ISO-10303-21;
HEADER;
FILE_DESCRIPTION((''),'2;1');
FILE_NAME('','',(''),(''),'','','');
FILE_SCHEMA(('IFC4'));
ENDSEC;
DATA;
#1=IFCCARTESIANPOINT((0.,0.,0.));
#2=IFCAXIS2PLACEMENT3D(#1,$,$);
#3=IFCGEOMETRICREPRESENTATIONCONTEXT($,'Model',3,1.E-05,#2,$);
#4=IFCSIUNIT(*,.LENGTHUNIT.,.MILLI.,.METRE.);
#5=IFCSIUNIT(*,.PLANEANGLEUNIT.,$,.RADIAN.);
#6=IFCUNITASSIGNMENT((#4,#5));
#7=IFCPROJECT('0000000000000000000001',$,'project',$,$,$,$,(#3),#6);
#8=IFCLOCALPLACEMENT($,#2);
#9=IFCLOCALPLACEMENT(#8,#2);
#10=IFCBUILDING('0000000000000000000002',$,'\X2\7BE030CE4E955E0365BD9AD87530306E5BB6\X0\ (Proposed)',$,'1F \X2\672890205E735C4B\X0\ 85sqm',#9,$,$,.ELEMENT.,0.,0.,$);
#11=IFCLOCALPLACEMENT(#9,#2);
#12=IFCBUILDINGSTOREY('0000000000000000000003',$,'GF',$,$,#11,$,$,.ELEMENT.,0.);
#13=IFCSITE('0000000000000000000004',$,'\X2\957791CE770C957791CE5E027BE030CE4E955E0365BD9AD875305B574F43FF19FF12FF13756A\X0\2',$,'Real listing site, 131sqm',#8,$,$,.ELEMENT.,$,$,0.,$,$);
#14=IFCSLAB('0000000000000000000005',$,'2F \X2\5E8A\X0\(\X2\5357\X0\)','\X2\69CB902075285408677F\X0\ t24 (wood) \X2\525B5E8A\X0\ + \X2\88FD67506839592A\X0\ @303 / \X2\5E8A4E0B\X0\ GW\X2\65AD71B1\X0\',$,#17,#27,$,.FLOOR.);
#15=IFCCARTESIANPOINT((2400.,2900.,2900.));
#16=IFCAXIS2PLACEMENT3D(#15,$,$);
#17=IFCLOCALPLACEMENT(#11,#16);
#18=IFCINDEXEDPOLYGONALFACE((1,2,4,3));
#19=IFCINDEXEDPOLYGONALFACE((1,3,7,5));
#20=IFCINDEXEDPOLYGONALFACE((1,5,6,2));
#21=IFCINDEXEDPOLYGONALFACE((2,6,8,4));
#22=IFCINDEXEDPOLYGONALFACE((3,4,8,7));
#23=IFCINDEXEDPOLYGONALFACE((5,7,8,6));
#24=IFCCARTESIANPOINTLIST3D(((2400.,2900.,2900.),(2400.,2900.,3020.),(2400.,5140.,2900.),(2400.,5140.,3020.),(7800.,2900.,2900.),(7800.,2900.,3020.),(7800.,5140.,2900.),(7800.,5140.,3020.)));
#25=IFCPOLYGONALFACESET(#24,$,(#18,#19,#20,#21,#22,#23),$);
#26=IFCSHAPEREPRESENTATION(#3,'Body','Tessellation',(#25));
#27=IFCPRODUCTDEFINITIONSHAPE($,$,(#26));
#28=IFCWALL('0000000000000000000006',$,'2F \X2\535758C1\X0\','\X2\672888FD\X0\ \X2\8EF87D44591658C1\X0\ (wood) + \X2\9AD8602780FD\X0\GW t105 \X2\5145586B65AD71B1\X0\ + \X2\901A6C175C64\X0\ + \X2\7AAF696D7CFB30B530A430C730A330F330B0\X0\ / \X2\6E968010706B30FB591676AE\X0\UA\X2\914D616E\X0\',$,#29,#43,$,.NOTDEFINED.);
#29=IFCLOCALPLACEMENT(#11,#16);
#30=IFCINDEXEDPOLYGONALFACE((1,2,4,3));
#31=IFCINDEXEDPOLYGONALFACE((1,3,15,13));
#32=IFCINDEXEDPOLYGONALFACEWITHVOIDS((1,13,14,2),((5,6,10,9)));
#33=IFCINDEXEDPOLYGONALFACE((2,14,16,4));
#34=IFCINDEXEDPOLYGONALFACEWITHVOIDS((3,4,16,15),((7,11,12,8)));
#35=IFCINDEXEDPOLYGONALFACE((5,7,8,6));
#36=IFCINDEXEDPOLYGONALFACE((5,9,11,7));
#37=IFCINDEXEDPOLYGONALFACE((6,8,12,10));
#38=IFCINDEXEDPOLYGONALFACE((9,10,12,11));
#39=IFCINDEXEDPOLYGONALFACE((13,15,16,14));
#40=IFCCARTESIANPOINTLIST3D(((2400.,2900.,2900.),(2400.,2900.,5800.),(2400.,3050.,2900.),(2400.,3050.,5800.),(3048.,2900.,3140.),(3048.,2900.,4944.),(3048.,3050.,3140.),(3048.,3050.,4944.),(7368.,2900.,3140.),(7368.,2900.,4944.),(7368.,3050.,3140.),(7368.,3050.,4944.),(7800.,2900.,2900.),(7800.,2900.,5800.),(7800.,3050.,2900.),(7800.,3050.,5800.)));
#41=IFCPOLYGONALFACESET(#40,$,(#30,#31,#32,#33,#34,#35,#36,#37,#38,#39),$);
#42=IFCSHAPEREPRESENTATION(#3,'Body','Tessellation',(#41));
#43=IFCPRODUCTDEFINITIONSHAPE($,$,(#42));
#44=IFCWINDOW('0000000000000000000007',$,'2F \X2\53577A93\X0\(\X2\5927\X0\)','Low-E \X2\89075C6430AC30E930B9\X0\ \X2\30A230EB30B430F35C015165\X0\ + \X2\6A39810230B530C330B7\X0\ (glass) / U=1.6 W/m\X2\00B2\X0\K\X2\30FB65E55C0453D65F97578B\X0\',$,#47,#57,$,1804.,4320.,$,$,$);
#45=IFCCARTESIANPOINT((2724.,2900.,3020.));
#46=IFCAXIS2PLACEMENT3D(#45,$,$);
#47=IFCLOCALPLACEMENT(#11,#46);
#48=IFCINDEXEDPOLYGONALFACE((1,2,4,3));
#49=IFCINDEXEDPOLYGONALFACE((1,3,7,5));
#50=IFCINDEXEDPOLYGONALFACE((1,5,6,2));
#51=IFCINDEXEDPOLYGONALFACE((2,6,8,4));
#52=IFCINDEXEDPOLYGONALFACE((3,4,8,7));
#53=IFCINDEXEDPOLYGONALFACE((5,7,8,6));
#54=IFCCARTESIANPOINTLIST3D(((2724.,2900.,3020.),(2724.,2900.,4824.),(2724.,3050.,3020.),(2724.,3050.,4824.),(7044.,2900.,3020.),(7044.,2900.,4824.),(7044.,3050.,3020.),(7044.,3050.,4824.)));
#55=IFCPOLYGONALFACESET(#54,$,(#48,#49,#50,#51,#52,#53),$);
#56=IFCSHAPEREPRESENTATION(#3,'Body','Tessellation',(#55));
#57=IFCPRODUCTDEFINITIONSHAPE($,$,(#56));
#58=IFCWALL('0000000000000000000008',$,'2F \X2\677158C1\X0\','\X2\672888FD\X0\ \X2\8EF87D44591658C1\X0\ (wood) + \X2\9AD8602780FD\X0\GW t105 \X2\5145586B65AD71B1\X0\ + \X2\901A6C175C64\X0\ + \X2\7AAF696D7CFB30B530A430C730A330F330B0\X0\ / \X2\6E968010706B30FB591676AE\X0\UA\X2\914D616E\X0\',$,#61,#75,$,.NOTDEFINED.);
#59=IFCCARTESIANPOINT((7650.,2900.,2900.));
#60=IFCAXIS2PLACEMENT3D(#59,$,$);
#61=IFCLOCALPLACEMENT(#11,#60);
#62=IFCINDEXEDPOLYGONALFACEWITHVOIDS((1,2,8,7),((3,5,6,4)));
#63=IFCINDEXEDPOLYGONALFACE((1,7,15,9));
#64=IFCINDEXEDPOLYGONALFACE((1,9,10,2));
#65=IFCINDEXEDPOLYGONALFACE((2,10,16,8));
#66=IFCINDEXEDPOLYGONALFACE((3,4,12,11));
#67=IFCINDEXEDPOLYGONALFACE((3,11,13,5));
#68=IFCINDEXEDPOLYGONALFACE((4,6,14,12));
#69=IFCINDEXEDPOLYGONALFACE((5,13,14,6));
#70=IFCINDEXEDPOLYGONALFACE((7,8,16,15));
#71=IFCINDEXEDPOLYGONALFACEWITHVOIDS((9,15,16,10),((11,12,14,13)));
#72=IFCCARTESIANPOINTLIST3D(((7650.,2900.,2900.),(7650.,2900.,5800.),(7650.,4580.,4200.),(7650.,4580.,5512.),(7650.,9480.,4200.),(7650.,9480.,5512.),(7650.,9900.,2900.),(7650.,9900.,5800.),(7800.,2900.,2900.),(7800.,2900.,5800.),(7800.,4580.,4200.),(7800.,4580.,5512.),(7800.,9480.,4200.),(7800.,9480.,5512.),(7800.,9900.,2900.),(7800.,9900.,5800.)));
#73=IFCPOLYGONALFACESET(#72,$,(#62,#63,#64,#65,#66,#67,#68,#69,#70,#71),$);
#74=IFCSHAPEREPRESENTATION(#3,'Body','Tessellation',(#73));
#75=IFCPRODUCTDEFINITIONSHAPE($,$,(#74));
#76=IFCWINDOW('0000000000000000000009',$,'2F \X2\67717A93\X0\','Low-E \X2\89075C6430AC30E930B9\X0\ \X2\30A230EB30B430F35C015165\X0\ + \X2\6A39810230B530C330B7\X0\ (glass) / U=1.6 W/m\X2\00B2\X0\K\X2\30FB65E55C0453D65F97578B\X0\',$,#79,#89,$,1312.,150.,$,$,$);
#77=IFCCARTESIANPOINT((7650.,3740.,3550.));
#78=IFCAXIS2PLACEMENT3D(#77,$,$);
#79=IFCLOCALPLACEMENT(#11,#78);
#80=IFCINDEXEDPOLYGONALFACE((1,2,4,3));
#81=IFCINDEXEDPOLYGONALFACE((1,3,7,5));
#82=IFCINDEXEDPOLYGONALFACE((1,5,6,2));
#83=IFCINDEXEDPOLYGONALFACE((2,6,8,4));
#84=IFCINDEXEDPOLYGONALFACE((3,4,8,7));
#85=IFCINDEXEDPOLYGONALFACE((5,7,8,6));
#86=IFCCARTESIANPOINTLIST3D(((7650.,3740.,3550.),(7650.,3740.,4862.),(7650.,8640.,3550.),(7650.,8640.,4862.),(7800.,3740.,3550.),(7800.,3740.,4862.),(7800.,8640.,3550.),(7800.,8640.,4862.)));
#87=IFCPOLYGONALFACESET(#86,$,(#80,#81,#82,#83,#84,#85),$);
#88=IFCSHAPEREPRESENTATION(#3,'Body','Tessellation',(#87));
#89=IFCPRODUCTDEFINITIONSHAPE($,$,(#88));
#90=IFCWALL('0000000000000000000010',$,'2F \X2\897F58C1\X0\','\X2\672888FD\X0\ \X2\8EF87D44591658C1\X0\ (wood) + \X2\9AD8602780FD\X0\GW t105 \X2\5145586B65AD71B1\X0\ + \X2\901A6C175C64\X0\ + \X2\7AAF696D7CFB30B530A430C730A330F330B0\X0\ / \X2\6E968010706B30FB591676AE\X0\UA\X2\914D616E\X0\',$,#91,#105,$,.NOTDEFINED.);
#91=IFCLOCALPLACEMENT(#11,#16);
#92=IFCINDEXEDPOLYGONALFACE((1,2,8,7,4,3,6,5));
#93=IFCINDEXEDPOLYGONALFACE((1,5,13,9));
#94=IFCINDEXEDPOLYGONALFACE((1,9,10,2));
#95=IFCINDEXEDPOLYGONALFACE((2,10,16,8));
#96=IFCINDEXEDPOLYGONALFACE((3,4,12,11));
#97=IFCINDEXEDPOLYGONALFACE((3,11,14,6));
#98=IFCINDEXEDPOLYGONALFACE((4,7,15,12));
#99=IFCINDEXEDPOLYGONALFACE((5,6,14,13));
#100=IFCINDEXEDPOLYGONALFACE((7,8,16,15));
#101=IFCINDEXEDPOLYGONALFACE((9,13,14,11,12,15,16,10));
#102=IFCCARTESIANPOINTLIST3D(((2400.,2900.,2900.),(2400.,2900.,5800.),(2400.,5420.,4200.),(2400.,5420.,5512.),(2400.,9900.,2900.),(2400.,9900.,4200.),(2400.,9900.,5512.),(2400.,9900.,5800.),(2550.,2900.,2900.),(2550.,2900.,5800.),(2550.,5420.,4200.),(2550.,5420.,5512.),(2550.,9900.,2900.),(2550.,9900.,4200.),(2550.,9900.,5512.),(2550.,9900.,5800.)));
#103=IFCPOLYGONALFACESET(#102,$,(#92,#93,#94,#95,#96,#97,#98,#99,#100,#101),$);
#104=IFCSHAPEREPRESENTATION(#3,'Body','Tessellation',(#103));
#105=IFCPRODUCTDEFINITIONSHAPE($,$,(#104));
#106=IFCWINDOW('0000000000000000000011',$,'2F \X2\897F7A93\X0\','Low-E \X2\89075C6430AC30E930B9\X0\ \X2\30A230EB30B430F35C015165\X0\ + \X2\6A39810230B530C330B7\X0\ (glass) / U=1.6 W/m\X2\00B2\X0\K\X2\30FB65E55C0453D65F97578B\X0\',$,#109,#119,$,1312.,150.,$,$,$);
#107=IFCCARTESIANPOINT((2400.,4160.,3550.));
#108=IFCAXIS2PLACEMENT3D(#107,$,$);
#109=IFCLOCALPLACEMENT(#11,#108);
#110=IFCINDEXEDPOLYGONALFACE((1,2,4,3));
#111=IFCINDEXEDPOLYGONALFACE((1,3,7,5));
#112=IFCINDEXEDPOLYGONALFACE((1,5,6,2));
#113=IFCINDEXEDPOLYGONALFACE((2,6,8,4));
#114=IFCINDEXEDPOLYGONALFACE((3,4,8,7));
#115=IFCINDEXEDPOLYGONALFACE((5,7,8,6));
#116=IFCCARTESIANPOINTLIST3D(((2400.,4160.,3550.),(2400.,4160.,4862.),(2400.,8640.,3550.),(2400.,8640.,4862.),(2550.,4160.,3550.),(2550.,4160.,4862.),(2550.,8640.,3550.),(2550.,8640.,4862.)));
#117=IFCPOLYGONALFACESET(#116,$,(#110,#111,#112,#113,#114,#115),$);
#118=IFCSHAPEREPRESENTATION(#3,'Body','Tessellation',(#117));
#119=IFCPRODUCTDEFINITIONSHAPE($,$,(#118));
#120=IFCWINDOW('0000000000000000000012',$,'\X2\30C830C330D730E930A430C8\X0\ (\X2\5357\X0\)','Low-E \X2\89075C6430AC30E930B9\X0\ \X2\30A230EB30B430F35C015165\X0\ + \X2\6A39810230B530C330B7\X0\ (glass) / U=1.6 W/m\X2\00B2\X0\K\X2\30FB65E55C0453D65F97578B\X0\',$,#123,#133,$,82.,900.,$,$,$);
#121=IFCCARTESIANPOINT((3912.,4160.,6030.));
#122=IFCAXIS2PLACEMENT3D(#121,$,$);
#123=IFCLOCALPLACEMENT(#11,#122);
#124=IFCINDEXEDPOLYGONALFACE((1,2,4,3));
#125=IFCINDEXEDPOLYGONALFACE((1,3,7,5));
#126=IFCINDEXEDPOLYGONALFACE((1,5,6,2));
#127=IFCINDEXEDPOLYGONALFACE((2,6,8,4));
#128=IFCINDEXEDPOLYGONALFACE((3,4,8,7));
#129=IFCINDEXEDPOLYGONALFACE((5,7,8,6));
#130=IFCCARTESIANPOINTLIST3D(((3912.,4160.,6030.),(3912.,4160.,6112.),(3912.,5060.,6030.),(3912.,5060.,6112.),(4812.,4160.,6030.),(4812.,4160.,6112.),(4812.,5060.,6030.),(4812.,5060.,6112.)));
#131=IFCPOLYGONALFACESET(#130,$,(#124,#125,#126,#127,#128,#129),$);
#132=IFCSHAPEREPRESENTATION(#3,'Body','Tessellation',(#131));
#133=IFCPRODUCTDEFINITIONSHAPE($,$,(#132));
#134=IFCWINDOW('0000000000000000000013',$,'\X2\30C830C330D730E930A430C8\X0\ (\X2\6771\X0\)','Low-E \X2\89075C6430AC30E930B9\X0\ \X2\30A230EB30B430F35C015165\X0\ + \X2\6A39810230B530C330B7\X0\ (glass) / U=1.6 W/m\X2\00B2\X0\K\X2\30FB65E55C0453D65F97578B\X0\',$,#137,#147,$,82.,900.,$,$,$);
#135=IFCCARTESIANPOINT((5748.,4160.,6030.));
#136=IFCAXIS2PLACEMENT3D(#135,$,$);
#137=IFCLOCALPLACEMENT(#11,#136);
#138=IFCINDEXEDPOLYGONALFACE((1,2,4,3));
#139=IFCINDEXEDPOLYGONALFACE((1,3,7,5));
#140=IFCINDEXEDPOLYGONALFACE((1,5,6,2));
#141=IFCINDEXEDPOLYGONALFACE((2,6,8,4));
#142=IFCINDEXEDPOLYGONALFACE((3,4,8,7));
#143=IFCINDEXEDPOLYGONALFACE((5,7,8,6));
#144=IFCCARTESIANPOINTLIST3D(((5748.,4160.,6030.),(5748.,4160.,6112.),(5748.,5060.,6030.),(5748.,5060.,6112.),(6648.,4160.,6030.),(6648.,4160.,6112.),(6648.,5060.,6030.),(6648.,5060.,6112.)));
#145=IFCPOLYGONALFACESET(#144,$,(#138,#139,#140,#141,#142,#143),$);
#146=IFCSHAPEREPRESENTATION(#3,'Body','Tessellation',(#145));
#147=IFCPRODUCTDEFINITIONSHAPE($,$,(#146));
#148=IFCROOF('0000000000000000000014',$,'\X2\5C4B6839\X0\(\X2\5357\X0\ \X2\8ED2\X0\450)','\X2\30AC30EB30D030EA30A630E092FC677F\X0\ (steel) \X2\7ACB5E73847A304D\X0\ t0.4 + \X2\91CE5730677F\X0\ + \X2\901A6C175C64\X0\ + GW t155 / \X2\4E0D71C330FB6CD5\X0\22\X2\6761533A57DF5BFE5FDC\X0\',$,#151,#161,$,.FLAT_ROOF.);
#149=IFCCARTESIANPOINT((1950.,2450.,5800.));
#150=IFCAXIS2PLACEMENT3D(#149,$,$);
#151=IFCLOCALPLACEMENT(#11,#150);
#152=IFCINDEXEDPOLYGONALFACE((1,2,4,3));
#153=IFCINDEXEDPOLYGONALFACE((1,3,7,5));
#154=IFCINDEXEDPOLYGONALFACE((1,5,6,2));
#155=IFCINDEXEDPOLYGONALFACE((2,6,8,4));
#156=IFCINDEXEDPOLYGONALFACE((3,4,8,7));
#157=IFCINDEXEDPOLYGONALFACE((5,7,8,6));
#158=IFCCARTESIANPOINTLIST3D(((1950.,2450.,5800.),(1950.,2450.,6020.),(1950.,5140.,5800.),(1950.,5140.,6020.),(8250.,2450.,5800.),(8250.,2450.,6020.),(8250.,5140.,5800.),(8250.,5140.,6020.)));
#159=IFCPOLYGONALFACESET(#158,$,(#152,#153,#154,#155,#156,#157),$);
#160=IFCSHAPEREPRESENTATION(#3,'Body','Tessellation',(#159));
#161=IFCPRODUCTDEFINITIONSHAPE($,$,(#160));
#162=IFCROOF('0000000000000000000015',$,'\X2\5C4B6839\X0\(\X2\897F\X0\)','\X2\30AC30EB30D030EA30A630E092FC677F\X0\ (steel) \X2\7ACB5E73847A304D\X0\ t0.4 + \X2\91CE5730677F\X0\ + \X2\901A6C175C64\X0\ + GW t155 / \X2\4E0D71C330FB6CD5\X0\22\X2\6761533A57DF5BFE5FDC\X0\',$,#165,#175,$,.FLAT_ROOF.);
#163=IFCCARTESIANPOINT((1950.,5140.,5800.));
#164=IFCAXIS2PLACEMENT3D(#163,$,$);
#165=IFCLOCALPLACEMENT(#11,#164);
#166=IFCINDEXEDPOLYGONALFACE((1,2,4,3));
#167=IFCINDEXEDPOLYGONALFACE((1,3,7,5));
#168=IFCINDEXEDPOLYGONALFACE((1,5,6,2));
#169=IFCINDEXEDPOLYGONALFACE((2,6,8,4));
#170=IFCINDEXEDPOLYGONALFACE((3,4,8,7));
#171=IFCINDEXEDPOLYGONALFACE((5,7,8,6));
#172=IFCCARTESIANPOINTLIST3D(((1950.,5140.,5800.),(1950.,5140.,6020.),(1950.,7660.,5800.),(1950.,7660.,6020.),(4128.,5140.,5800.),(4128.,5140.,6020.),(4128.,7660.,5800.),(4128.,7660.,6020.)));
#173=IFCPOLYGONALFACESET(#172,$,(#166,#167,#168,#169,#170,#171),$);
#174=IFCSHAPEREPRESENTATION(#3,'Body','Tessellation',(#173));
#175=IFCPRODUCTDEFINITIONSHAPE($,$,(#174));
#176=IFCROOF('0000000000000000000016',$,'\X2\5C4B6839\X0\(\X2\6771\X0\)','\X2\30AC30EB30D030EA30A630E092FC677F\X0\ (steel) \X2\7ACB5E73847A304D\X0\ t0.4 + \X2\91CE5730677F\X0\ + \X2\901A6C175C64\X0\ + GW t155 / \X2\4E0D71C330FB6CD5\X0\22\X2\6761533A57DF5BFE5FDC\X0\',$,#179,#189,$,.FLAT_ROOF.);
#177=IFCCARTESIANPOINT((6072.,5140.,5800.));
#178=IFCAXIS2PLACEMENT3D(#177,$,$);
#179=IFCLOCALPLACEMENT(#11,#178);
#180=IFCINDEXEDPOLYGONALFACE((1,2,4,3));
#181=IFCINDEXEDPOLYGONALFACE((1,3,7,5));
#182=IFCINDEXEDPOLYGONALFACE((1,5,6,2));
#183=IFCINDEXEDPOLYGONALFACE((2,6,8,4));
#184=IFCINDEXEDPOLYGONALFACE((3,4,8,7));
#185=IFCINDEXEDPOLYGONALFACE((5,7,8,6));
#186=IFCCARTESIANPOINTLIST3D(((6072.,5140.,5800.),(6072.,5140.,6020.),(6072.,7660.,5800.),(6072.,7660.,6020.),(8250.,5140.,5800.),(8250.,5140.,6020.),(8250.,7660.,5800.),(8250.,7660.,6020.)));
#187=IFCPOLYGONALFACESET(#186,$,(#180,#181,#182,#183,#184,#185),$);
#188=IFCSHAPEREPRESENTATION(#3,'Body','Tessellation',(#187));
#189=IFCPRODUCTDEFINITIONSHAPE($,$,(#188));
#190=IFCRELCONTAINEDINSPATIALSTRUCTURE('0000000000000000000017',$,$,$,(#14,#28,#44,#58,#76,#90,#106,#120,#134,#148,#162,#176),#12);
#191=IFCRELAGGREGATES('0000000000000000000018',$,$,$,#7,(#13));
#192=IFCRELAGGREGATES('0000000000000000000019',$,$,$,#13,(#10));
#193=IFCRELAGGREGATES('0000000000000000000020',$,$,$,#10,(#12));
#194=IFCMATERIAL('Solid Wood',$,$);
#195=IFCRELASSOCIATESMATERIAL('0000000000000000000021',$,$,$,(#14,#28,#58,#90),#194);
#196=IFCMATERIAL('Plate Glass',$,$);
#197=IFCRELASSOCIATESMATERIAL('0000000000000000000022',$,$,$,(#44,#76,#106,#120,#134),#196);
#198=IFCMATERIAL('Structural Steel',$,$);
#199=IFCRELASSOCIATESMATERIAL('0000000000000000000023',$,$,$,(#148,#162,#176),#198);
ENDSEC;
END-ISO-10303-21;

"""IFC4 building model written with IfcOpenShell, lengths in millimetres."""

from ifc_helpers import new_model, si_unit, frame, frame_2d, origin, place, context, project, spatial, rectangle, extrude, material, element, fill, save


model = new_model("IFC4")

# Units and contexts
model_context = context("Model", 3, precision=1e-05, world=origin())
ifc_project = project(units=[si_unit("LENGTHUNIT", "METRE", prefix="MILLI"), si_unit("PLANEANGLEUNIT", "RADIAN")], contexts=[model_context])

# Site, building, storey
site_placement = place(None, origin())
site = spatial("IfcSite", under=ifc_project, at=site_placement, Name="長野県長野市篠ノ井布施高田字佃９２３番2", ObjectType="Real listing site, 131sqm", CompositionType="ELEMENT", RefElevation=0.0)
building_placement = place(site_placement, origin())
building = spatial("IfcBuilding", under=site, at=building_placement, Name="篠ノ井布施高田の家 (Proposed)", ObjectType="1F 木造平屋 85sqm", CompositionType="ELEMENT", ElevationOfRefHeight=0.0, ElevationOfTerrain=0.0)
storey_placement = place(building_placement, origin())
storey = spatial("IfcBuildingStorey", under=building, at=storey_placement, Name="GF", CompositionType="ELEMENT", Elevation=0.0)

# Slab
ifc_material_1 = material(Name="Solid Wood")
slab_placement = place(storey_placement, frame((2400.0, 2900.0, 2900.0)))
element("IfcSlab", 1, at=slab_placement, inside=storey, material=ifc_material_1, Name="2F 床(南)", Description="構造用合板 t24 (wood) 剛床 + 製材根太 @303 / 床下 GW断熱", PredefinedType="FLOOR", context=model_context, shape_type="SweptSolid", body=[
    extrude(rectangle(XDim=5400.0, YDim=2240.0, at=frame_2d((2700.0, 1120.0))), frame((2400.0, 2900.0, 2900.0)), (0.0, 0.0, 1.0), 120.0),
])

# Walls, openings, windows
wall_1_placement = place(storey_placement, frame((2400.0, 2900.0, 2900.0)))
wall_1 = element("IfcWall", 2, at=wall_1_placement, inside=storey, material=ifc_material_1, Name="2F 南壁", Description="木製 軸組外壁 (wood) + 高性能GW t105 充填断熱 + 通気層 + 窯業系サイディング / 準耐火・外皮UA配慮", PredefinedType="NOTDEFINED", context=model_context, shape_type="SweptSolid", body=[
    extrude(rectangle(XDim=5400.0, YDim=150.0, at=frame_2d((2700.0, 75.0))), frame((2400.0, 2900.0, 2900.0)), (0.0, 0.0, 1.0), 2900.0),
])
opening_1_placement = place(storey_placement, frame((2724.0, 2900.0, 3020.0)))
opening_1 = element("IfcOpeningElement", 3, at=opening_1_placement, cuts=wall_1, PredefinedType="NOTDEFINED", context=model_context, shape_type="SweptSolid", body=[
    extrude(rectangle(XDim=4320.0, YDim=150.0, at=frame_2d((2160.0, 75.0))), frame((2724.0, 2900.0, 3020.0)), (0.0, 0.0, 1.0), 1804.0),
])
ifc_material_2 = material(Name="Plate Glass")
window_1_placement = place(storey_placement, frame((2724.0, 2900.0, 3020.0)))
window_1 = element("IfcWindow", 4, at=window_1_placement, inside=storey, material=ifc_material_2, Name="2F 南窓(大)", Description="Low-E 複層ガラス アルゴン封入 + 樹脂サッシ (glass) / U=1.6 W/m²K・日射取得型", OverallHeight=1804.0, OverallWidth=4320.0, context=model_context, shape_type="SweptSolid", body=[
    extrude(rectangle(XDim=4320.0, YDim=150.0, at=frame_2d((2160.0, 75.0))), frame((2724.0, 2900.0, 3020.0)), (0.0, 0.0, 1.0), 1804.0),
])
fill(opening_1, window_1)
wall_2_placement = place(storey_placement, frame((7650.0, 2900.0, 2900.0)))
wall_2 = element("IfcWall", 5, at=wall_2_placement, inside=storey, material=ifc_material_1, Name="2F 東壁", Description="木製 軸組外壁 (wood) + 高性能GW t105 充填断熱 + 通気層 + 窯業系サイディング / 準耐火・外皮UA配慮", PredefinedType="NOTDEFINED", context=model_context, shape_type="SweptSolid", body=[
    extrude(rectangle(XDim=150.0, YDim=7000.0, at=frame_2d((75.0, 3500.0))), frame((7650.0, 2900.0, 2900.0)), (0.0, 0.0, 1.0), 2900.0),
])
opening_2_placement = place(storey_placement, frame((7650.0, 3740.0, 3550.0)))
opening_2 = element("IfcOpeningElement", 6, at=opening_2_placement, cuts=wall_2, PredefinedType="NOTDEFINED", context=model_context, shape_type="SweptSolid", body=[
    extrude(rectangle(XDim=150.0, YDim=4900.0, at=frame_2d((75.0, 2450.0))), frame((7650.0, 3740.0, 3550.0)), (0.0, 0.0, 1.0), 1312.0),
])
window_2_placement = place(storey_placement, frame((7650.0, 3740.0, 3550.0)))
window_2 = element("IfcWindow", 7, at=window_2_placement, inside=storey, material=ifc_material_2, Name="2F 東窓", Description="Low-E 複層ガラス アルゴン封入 + 樹脂サッシ (glass) / U=1.6 W/m²K・日射取得型", OverallHeight=1312.0, OverallWidth=150.0, context=model_context, shape_type="SweptSolid", body=[
    extrude(rectangle(XDim=150.0, YDim=4900.0, at=frame_2d((75.0, 2450.0))), frame((7650.0, 3740.0, 3550.0)), (0.0, 0.0, 1.0), 1312.0),
])
fill(opening_2, window_2)
wall_3_placement = place(storey_placement, frame((2400.0, 2900.0, 2900.0)))
wall_3 = element("IfcWall", 8, at=wall_3_placement, inside=storey, material=ifc_material_1, Name="2F 西壁", Description="木製 軸組外壁 (wood) + 高性能GW t105 充填断熱 + 通気層 + 窯業系サイディング / 準耐火・外皮UA配慮", PredefinedType="NOTDEFINED", context=model_context, shape_type="SweptSolid", body=[
    extrude(rectangle(XDim=150.0, YDim=7000.0, at=frame_2d((75.0, 3500.0))), frame((2400.0, 2900.0, 2900.0)), (0.0, 0.0, 1.0), 2900.0),
])
opening_3_placement = place(storey_placement, frame((2400.0, 4160.0, 3550.0)))
opening_3 = element("IfcOpeningElement", 9, at=opening_3_placement, cuts=wall_3, PredefinedType="NOTDEFINED", context=model_context, shape_type="SweptSolid", body=[
    extrude(rectangle(XDim=150.0, YDim=4480.0, at=frame_2d((75.0, 2240.0))), frame((2400.0, 4160.0, 3550.0)), (0.0, 0.0, 1.0), 1312.0),
])
window_3_placement = place(storey_placement, frame((2400.0, 4160.0, 3550.0)))
window_3 = element("IfcWindow", 10, at=window_3_placement, inside=storey, material=ifc_material_2, Name="2F 西窓", Description="Low-E 複層ガラス アルゴン封入 + 樹脂サッシ (glass) / U=1.6 W/m²K・日射取得型", OverallHeight=1312.0, OverallWidth=150.0, context=model_context, shape_type="SweptSolid", body=[
    extrude(rectangle(XDim=150.0, YDim=4480.0, at=frame_2d((75.0, 2240.0))), frame((2400.0, 4160.0, 3550.0)), (0.0, 0.0, 1.0), 1312.0),
])
fill(opening_3, window_3)

# Windows
window_4_placement = place(storey_placement, frame((3912.0, 4160.0, 6030.0)))
element("IfcWindow", 11, at=window_4_placement, inside=storey, material=ifc_material_2, Name="トップライト (南)", Description="Low-E 複層ガラス アルゴン封入 + 樹脂サッシ (glass) / U=1.6 W/m²K・日射取得型", OverallHeight=82.0, OverallWidth=900.0, context=model_context, shape_type="SweptSolid", body=[
    extrude(rectangle(XDim=900.0, YDim=900.0, at=frame_2d((450.0, 450.0))), frame((3912.0, 4160.0, 6030.0)), (0.0, 0.0, 1.0), 82.0),
])
window_5_placement = place(storey_placement, frame((5748.0, 4160.0, 6030.0)))
element("IfcWindow", 12, at=window_5_placement, inside=storey, material=ifc_material_2, Name="トップライト (東)", Description="Low-E 複層ガラス アルゴン封入 + 樹脂サッシ (glass) / U=1.6 W/m²K・日射取得型", OverallHeight=82.0, OverallWidth=900.0, context=model_context, shape_type="SweptSolid", body=[
    extrude(rectangle(XDim=900.0, YDim=900.0, at=frame_2d((450.0, 450.0))), frame((5748.0, 4160.0, 6030.0)), (0.0, 0.0, 1.0), 82.0),
])

# Roofs
ifc_material_3 = material(Name="Structural Steel")
roof_1_placement = place(storey_placement, frame((1950.0, 2450.0, 5800.0)))
element("IfcRoof", 13, at=roof_1_placement, inside=storey, material=ifc_material_3, Name="屋根(南 軒450)", Description="ガルバリウム鋼板 (steel) 立平葺き t0.4 + 野地板 + 通気層 + GW t155 / 不燃・法22条区域対応", PredefinedType="FLAT_ROOF", context=model_context, shape_type="SweptSolid", body=[
    extrude(rectangle(XDim=6300.0, YDim=2690.0, at=frame_2d((3150.0, 1345.0))), frame((1950.0, 2450.0, 5800.0)), (0.0, 0.0, 1.0), 220.0),
])
roof_2_placement = place(storey_placement, frame((1950.0, 5140.0, 5800.0)))
element("IfcRoof", 14, at=roof_2_placement, inside=storey, material=ifc_material_3, Name="屋根(西)", Description="ガルバリウム鋼板 (steel) 立平葺き t0.4 + 野地板 + 通気層 + GW t155 / 不燃・法22条区域対応", PredefinedType="FLAT_ROOF", context=model_context, shape_type="SweptSolid", body=[
    extrude(rectangle(XDim=2178.0, YDim=2520.0, at=frame_2d((1089.0, 1260.0))), frame((1950.0, 5140.0, 5800.0)), (0.0, 0.0, 1.0), 220.0),
])
roof_3_placement = place(storey_placement, frame((6072.0, 5140.0, 5800.0)))
element("IfcRoof", 15, at=roof_3_placement, inside=storey, material=ifc_material_3, Name="屋根(東)", Description="ガルバリウム鋼板 (steel) 立平葺き t0.4 + 野地板 + 通気層 + GW t155 / 不燃・法22条区域対応", PredefinedType="FLAT_ROOF", context=model_context, shape_type="SweptSolid", body=[
    extrude(rectangle(XDim=2178.0, YDim=2520.0, at=frame_2d((1089.0, 1260.0))), frame((6072.0, 5140.0, 5800.0)), (0.0, 0.0, 1.0), 220.0),
])

save(model, "model.ifc")
